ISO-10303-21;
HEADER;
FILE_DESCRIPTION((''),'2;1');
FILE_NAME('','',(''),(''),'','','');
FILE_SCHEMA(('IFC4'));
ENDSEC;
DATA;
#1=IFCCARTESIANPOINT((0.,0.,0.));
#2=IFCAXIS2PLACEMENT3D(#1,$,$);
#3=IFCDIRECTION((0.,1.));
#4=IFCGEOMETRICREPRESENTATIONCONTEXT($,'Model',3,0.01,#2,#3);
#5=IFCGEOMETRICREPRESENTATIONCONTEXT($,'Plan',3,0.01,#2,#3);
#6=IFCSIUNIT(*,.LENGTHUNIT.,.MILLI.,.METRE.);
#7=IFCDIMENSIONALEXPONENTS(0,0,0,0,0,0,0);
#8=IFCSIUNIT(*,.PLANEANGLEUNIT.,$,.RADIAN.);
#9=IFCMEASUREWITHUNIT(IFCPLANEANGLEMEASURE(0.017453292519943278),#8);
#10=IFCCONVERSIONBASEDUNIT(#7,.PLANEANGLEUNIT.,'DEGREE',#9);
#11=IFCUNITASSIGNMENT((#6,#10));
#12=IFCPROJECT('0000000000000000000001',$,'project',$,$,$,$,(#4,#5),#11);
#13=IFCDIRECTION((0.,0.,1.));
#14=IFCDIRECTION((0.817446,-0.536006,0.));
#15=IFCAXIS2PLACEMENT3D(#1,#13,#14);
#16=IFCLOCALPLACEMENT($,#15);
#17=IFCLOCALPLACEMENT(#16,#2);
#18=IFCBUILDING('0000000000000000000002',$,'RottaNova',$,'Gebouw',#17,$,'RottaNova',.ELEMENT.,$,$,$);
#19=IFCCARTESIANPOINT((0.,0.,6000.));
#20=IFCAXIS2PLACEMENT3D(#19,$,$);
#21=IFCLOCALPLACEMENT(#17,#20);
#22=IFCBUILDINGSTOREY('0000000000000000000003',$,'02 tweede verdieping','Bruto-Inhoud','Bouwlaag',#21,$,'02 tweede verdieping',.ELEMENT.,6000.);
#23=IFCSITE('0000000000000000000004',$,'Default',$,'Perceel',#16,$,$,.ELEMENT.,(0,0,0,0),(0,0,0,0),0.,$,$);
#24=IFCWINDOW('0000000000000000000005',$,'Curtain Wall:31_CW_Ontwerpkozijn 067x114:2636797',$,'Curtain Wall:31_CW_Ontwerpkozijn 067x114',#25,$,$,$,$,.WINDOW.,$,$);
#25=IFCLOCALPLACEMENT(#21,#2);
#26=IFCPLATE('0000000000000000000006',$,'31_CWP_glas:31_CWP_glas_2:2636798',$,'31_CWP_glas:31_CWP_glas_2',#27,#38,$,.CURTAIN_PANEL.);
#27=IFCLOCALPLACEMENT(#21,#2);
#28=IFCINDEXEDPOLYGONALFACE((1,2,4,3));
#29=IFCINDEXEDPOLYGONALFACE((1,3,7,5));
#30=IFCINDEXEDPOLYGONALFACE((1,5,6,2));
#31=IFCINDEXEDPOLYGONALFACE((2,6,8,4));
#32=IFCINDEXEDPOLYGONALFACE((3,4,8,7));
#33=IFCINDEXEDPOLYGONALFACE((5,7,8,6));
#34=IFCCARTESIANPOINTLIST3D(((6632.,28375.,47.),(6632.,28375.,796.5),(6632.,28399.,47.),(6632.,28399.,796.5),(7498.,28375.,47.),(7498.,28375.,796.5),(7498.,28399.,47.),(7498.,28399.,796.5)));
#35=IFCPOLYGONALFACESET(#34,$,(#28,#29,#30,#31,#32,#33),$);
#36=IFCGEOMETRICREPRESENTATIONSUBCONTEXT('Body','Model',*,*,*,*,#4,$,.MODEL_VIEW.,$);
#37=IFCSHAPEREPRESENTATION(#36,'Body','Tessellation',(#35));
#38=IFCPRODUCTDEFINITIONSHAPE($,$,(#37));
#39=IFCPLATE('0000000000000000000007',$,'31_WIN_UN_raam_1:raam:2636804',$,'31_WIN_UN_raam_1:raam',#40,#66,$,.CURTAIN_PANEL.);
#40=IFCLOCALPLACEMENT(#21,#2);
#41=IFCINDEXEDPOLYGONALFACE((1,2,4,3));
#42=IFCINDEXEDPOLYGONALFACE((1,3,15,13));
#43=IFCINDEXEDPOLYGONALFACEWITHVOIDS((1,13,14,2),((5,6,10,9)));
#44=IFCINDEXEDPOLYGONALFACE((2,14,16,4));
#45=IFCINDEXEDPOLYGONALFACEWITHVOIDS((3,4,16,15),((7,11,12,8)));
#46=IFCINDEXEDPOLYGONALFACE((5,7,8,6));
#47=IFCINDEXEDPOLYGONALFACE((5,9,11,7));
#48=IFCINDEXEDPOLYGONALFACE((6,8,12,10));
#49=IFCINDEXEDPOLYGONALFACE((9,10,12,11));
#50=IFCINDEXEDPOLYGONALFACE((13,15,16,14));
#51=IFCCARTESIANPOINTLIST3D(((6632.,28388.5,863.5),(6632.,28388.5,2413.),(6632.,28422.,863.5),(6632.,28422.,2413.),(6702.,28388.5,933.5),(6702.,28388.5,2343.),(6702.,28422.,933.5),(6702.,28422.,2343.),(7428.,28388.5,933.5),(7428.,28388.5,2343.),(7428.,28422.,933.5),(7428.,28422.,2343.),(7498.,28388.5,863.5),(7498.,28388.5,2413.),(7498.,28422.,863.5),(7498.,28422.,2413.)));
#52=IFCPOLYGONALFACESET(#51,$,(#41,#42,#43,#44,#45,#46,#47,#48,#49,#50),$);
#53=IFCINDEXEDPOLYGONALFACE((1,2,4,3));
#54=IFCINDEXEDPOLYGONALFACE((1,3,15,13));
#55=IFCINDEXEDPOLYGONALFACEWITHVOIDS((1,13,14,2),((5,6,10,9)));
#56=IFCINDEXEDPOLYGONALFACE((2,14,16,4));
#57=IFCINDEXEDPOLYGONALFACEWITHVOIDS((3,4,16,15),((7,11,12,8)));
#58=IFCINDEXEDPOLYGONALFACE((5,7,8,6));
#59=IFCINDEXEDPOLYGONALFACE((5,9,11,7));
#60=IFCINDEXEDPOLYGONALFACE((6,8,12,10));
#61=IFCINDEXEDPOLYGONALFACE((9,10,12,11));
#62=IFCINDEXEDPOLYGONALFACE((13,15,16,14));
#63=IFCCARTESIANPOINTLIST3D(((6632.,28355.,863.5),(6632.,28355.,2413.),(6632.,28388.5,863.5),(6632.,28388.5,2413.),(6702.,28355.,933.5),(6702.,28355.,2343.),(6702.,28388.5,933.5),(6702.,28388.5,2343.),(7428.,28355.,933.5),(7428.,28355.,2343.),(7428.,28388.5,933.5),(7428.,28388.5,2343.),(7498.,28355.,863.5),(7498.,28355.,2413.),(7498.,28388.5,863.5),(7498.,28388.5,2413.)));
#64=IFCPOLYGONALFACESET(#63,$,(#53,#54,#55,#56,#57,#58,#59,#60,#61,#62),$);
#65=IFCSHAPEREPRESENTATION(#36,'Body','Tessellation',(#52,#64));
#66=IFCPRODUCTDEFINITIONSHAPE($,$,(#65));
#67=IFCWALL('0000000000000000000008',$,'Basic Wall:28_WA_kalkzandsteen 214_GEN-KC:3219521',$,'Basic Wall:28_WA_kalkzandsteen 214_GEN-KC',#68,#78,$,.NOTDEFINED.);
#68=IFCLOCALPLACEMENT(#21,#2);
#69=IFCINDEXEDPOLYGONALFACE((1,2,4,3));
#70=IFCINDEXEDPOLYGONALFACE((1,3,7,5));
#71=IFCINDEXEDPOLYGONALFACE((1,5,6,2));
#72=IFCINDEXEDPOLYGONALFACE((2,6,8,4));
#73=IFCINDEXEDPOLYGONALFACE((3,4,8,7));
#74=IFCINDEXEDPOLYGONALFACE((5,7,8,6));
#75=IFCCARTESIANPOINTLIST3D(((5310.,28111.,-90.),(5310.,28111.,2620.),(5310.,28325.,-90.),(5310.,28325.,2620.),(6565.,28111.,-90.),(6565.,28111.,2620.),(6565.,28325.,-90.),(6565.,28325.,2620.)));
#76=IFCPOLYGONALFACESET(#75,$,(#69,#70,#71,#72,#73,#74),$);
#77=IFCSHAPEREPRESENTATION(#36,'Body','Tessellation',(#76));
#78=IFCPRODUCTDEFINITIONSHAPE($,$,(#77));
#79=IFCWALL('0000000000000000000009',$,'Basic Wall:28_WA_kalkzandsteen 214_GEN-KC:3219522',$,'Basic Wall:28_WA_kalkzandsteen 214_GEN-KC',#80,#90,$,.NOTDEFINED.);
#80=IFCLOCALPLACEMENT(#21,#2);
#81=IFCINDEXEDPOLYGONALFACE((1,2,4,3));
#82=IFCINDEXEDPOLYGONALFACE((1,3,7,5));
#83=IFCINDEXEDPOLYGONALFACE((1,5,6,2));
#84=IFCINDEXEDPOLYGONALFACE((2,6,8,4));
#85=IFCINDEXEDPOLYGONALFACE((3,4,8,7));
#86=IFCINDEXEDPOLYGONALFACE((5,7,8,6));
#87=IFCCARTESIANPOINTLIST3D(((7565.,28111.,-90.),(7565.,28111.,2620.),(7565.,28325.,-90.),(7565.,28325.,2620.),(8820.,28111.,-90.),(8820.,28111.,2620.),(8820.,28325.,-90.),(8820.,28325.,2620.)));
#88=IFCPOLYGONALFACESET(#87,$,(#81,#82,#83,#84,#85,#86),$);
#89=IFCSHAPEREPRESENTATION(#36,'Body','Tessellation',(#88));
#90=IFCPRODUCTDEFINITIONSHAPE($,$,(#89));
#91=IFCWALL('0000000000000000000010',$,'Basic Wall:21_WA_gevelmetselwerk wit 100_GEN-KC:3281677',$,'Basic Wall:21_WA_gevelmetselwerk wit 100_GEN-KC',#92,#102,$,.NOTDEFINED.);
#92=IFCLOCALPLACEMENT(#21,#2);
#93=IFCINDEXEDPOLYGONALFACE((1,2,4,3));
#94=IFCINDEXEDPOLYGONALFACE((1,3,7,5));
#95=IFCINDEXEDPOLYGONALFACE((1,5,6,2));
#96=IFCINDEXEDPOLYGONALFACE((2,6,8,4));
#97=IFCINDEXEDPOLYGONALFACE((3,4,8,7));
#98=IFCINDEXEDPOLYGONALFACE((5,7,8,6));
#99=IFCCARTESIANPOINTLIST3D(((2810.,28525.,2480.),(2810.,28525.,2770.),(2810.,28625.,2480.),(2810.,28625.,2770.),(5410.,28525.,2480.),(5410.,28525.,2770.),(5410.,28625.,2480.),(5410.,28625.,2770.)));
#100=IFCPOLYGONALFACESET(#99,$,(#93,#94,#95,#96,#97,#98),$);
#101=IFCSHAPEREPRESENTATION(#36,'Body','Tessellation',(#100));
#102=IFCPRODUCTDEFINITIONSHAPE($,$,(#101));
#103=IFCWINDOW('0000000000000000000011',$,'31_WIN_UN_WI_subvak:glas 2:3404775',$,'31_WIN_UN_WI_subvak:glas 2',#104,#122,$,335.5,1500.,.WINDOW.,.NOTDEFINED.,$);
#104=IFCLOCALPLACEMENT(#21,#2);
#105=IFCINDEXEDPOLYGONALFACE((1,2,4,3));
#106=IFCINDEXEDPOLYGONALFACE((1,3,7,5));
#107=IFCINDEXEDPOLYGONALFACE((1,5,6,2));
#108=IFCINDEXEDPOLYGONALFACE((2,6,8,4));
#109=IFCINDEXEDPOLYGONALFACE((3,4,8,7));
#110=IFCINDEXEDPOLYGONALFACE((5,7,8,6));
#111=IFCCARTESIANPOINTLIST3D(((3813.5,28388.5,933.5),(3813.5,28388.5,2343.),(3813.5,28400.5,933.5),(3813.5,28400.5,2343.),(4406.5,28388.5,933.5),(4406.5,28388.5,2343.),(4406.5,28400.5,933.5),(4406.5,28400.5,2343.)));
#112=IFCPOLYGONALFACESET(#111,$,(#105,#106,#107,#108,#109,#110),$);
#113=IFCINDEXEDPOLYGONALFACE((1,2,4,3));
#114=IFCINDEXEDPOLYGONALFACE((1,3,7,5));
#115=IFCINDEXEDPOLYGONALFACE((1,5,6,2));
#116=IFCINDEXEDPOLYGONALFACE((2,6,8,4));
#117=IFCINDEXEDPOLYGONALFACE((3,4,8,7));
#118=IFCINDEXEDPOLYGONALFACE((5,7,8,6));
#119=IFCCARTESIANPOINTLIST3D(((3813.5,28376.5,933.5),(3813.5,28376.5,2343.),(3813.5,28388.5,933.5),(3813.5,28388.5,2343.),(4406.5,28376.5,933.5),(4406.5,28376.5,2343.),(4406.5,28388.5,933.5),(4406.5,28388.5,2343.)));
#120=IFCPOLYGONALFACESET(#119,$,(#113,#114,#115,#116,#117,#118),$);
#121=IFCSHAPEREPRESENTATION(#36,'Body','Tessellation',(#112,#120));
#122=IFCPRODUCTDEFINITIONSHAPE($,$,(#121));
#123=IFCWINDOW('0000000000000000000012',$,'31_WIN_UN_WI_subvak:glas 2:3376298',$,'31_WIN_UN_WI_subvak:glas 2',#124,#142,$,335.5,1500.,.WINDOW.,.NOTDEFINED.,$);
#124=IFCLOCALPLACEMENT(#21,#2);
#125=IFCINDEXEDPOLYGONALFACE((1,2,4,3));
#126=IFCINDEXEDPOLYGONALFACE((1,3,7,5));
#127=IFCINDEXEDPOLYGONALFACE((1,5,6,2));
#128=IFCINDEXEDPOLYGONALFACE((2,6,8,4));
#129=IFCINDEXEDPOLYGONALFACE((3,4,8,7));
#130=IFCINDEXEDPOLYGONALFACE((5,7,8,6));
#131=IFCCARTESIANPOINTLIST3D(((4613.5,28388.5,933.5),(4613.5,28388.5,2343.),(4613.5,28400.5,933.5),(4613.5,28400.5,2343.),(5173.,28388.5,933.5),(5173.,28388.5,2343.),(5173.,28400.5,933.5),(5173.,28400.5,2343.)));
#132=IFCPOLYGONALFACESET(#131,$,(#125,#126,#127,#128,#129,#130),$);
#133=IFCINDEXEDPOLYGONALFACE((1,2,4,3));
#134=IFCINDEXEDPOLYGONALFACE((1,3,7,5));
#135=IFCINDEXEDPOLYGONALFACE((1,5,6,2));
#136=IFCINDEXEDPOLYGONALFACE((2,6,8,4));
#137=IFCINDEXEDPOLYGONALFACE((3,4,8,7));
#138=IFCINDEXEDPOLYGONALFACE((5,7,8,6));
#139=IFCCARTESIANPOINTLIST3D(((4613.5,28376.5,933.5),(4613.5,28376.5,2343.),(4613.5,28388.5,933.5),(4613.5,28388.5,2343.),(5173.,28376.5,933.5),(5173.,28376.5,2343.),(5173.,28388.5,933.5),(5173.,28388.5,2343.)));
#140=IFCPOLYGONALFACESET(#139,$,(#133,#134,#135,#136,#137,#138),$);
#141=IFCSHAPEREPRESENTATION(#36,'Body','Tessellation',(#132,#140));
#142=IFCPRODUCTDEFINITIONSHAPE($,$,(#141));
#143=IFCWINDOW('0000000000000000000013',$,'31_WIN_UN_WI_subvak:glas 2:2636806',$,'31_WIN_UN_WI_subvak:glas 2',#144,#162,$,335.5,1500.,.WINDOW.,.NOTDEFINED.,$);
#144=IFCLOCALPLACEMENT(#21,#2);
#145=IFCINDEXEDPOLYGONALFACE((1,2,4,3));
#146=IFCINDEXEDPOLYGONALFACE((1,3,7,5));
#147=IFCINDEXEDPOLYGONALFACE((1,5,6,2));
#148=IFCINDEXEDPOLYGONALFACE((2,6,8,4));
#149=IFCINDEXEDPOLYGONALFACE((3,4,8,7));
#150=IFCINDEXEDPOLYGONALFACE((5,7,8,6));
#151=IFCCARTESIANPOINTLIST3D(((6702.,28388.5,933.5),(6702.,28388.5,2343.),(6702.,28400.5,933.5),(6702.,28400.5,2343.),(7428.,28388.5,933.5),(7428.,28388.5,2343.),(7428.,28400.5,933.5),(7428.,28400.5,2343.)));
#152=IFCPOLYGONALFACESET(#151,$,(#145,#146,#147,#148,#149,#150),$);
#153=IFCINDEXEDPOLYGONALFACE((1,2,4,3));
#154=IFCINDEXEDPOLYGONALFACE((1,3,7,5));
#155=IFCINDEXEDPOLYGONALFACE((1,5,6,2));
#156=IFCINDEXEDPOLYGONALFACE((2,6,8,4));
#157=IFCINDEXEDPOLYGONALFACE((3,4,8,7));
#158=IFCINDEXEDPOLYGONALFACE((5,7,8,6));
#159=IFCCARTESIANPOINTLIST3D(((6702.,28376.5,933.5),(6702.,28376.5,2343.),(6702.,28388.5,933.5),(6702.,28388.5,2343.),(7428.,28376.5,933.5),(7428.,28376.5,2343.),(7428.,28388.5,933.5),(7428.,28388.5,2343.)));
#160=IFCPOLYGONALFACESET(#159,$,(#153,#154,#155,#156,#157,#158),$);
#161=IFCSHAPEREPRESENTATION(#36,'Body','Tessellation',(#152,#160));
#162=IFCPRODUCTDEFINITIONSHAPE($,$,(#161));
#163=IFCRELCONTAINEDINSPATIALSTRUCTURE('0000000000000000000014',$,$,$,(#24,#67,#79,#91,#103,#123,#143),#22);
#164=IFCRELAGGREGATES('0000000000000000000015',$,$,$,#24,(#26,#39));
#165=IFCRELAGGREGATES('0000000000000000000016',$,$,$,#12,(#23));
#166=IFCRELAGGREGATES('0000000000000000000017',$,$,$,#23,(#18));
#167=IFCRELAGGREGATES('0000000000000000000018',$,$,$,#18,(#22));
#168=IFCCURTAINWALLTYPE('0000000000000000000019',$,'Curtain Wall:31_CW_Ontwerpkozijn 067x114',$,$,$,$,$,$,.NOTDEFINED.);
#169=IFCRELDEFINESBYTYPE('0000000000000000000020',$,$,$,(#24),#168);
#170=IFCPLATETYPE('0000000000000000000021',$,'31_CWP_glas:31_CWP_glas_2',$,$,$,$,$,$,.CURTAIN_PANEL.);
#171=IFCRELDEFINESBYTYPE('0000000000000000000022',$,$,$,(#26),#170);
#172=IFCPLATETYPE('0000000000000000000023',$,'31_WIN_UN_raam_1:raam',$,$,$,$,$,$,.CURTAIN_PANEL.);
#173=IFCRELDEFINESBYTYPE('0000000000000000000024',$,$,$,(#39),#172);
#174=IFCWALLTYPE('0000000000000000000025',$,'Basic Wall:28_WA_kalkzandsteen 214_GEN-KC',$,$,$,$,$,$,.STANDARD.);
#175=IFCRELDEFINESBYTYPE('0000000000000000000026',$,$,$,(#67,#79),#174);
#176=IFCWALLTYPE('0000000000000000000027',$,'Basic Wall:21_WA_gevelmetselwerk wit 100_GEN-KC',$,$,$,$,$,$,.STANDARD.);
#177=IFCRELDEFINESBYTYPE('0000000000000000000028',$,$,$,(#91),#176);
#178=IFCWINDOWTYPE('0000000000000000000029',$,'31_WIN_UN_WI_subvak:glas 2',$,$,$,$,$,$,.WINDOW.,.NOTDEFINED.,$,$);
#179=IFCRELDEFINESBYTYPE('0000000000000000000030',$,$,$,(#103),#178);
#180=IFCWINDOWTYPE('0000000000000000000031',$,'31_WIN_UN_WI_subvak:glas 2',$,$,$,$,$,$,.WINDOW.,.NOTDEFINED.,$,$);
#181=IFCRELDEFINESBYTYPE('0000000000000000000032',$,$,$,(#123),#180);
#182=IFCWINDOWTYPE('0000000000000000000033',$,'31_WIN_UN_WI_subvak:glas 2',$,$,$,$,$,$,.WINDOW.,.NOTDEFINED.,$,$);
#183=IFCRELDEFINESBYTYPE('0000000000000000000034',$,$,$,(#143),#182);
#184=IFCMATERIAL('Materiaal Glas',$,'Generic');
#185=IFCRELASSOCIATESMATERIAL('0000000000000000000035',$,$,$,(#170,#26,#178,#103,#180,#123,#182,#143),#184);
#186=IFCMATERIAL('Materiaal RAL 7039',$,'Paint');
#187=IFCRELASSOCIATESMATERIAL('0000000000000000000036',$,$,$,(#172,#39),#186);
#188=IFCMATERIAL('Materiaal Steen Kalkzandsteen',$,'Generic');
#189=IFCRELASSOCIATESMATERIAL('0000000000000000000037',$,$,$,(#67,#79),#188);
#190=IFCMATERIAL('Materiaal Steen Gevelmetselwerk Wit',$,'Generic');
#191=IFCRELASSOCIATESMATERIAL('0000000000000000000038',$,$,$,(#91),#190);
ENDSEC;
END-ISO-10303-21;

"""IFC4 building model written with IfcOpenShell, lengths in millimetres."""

from ifc_helpers import new_model, entity, si_unit, converted_unit, direction, frame, origin, place, context, subcontext, project, spatial, indexed_curve, outline, extrude, source, transform, mapped, material, type_object, type_shapes, element, aggregate, save


model = new_model("IFC4")

# Units and contexts
model_context = context("Model", 3, precision=0.01, world=origin(), true_north=direction((0.0, 1.0)))
plan_context = context("Plan", 3, precision=0.01, world=origin(), true_north=direction((0.0, 1.0)))
body_context = subcontext(model_context, "Body", "Model", "MODEL_VIEW")
ifc_project = project(units=[si_unit("LENGTHUNIT", "METRE", prefix="MILLI"), converted_unit("PLANEANGLEUNIT", "DEGREE", entity("IfcPlaneAngleMeasure", 0.017453292519943278), si_unit("PLANEANGLEUNIT", "RADIAN"), dimensions=[0, 0, 0, 0, 0, 0, 0])], contexts=[model_context, plan_context])

# Site, building, storey
site_placement = place(None, frame((0.0, 0.0, 0.0), z_axis=(0.0, 0.0, 1.0), x_axis=(0.817446, -0.536006, 0.0)))
site = spatial("IfcSite", under=ifc_project, at=site_placement, Name="Default", ObjectType="Perceel", CompositionType="ELEMENT", RefLatitude=(0, 0, 0, 0), RefLongitude=(0, 0, 0, 0), RefElevation=0.0)
building_placement = place(site_placement, origin())
building = spatial("IfcBuilding", under=site, at=building_placement, Name="RottaNova", ObjectType="Gebouw", LongName="RottaNova", CompositionType="ELEMENT")
storey_placement = place(building_placement, frame((0.0, 0.0, 6000.0)))
storey = spatial("IfcBuildingStorey", under=building, at=storey_placement, Name="02 tweede verdieping", Description="Bruto-Inhoud", ObjectType="Bouwlaag", LongName="02 tweede verdieping", CompositionType="ELEMENT", Elevation=6000.0)

# Window
curtain_wall_type = type_object("IfcCurtainWallType", Name="Curtain Wall:31_CW_Ontwerpkozijn 067x114", PredefinedType="NOTDEFINED")
window_1_placement = place(storey_placement, frame((0.0, 0.0, -6000.0)))
window_1 = element("IfcWindow", 1, at=window_1_placement, inside=storey, type_object=curtain_wall_type, Name="Curtain Wall:31_CW_Ontwerpkozijn 067x114:2636797", ObjectType="Curtain Wall:31_CW_Ontwerpkozijn 067x114", PredefinedType="WINDOW")

# Plates
ifc_material_1 = material(Name="Materiaal Glas", Category="Generic")
ifc_material_2 = material(Name="Materiaal RAL 7039", Category="Paint")
plate_type_1 = type_object("IfcPlateType", Name="31_CWP_glas:31_CWP_glas_2", PredefinedType="CURTAIN_PANEL", material=ifc_material_1)
shared_shape_1 = source(origin(), body_context, "Body", "SweptSolid", [
    extrude(outline(indexed_curve([(-12.0, -433.0), (12.0, -433.0), (12.0, 433.0), (-12.0, 433.0), (-12.0, -433.0)], self_intersect=False)), frame((0.0, 57.0, 0.0), z_axis=(0.0, 0.0, 1.0), x_axis=(0.0, 1.0, 0.0)), (0.0, 0.0, 1.0), 749.5),
])
type_shapes(plate_type_1, [shared_shape_1])
plate_1_placement = place(window_1_placement, frame((7065.0, 28330.0, 6047.0)))
plate_1 = element("IfcPlate", 2, at=plate_1_placement, type_object=plate_type_1, material=ifc_material_1, Name="31_CWP_glas:31_CWP_glas_2:2636798", ObjectType="31_CWP_glas:31_CWP_glas_2", PredefinedType="CURTAIN_PANEL", context=body_context, shape_type="MappedRepresentation", body=[
    mapped(shared_shape_1, transform((0.0, 0.0, 0.0), scale=1.0)),
])
plate_type_2 = type_object("IfcPlateType", Name="31_WIN_UN_raam_1:raam", PredefinedType="CURTAIN_PANEL", material=ifc_material_2)
shared_shape_2 = source(origin(), body_context, "Body", "SweptSolid", [
    extrude(outline(indexed_curve([(-433.0, -774.7), (433.0, -774.7), (433.0, 774.7), (-433.0, 774.7), (-433.0, -774.7)], self_intersect=False), holes=[indexed_curve([(-363.0, 704.7), (363.0, 704.7), (363.0, -704.8), (-363.0, -704.8), (-363.0, 704.7)], self_intersect=False)]), frame((0.0, 58.5, 774.8), z_axis=(0.0, 1.0, 0.0), x_axis=(1.0, 0.0, 0.0)), (0.0, 0.0, 1.0), 33.5),
    extrude(outline(indexed_curve([(-433.0, -774.7), (433.0, -774.7), (433.0, 774.7), (-433.0, 774.7), (-433.0, -774.7)], self_intersect=False), holes=[indexed_curve([(-363.0, 704.7), (363.0, 704.7), (363.0, -704.8), (-363.0, -704.8), (-363.0, 704.7)], self_intersect=False)]), frame((0.0, 25.0, 774.8), z_axis=(0.0, 1.0, 0.0), x_axis=(1.0, 0.0, 0.0)), (0.0, 0.0, 1.0), 33.5),
])
type_shapes(plate_type_2, [shared_shape_2])
plate_2_placement = place(window_1_placement, frame((7065.0, 28330.0, 6863.5)))
plate_2 = element("IfcPlate", 3, at=plate_2_placement, type_object=plate_type_2, material=ifc_material_2, Name="31_WIN_UN_raam_1:raam:2636804", ObjectType="31_WIN_UN_raam_1:raam", PredefinedType="CURTAIN_PANEL", context=body_context, shape_type="MappedRepresentation", body=[
    mapped(shared_shape_2, transform((0.0, 0.0, 0.0), scale=1.0)),
])
aggregate(window_1, [plate_1, plate_2])

# Walls
ifc_material_3 = material(Name="Materiaal Steen Kalkzandsteen", Category="Generic")
wall_type_1 = type_object("IfcWallType", Name="Basic Wall:28_WA_kalkzandsteen 214_GEN-KC", PredefinedType="STANDARD")
wall_1_placement = place(storey_placement, frame((5310.0, 28218.0, -90.0)))
element("IfcWall", 4, at=wall_1_placement, inside=storey, type_object=wall_type_1, material=ifc_material_3, Name="Basic Wall:28_WA_kalkzandsteen 214_GEN-KC:3219521", ObjectType="Basic Wall:28_WA_kalkzandsteen 214_GEN-KC", PredefinedType="NOTDEFINED", context=body_context, shape_type="SweptSolid", body=[
    extrude(outline(indexed_curve([(1255.0, 107.0), (0.0, 107.0), (0.0, -107.0), (1255.0, -107.0), (1255.0, 107.0)], self_intersect=False)), origin(), (0.0, 0.0, 1.0), 2710.0),
])
wall_2_placement = place(storey_placement, frame((7565.0, 28218.0, -90.0)))
element("IfcWall", 5, at=wall_2_placement, inside=storey, type_object=wall_type_1, material=ifc_material_3, Name="Basic Wall:28_WA_kalkzandsteen 214_GEN-KC:3219522", ObjectType="Basic Wall:28_WA_kalkzandsteen 214_GEN-KC", PredefinedType="NOTDEFINED", context=body_context, shape_type="SweptSolid", body=[
    extrude(outline(indexed_curve([(1255.0, 107.0), (0.0, 107.0), (0.0, -107.0), (1255.0, -107.0), (1255.0, 107.0)], self_intersect=False)), origin(), (0.0, 0.0, 1.0), 2710.0),
])
ifc_material_4 = material(Name="Materiaal Steen Gevelmetselwerk Wit", Category="Generic")
wall_type_2 = type_object("IfcWallType", Name="Basic Wall:21_WA_gevelmetselwerk wit 100_GEN-KC", PredefinedType="STANDARD")
wall_3_placement = place(storey_placement, frame((5410.0, 28575.0, 2480.0), z_axis=(0.0, 0.0, 1.0), x_axis=(-1.0, 0.0, 0.0)))
element("IfcWall", 6, at=wall_3_placement, inside=storey, type_object=wall_type_2, material=ifc_material_4, Name="Basic Wall:21_WA_gevelmetselwerk wit 100_GEN-KC:3281677", ObjectType="Basic Wall:21_WA_gevelmetselwerk wit 100_GEN-KC", PredefinedType="NOTDEFINED", context=body_context, shape_type="SweptSolid", body=[
    extrude(outline(indexed_curve([(2600.0, 50.0), (0.0, 50.0), (0.0, -50.0), (2600.0, -50.0), (2600.0, 50.0)], self_intersect=False)), origin(), (0.0, 0.0, 1.0), 290.0),
])

# Windows
window_type_1 = type_object("IfcWindowType", Name="31_WIN_UN_WI_subvak:glas 2", PartitioningType="NOTDEFINED", PredefinedType="WINDOW", material=ifc_material_1)
shared_shape_3 = source(origin(), body_context, "Body", "SweptSolid", [
    extrude(outline(indexed_curve([(-296.5, -6.0), (296.5, -6.0), (296.5, 6.0), (-296.5, 6.0), (-296.5, -6.0)], self_intersect=False)), frame((0.0, -6.0, 0.0)), (0.0, 0.0, 1.0), 1409.5),
    extrude(outline(indexed_curve([(-296.5, -6.0), (296.5, -6.0), (296.5, 6.0), (-296.5, 6.0), (-296.5, -6.0)], self_intersect=False)), frame((0.0, 6.0, 0.0)), (0.0, 0.0, 1.0), 1409.5),
])
type_shapes(window_type_1, [shared_shape_3])
window_2_placement = place(storey_placement, frame((4110.0, 28388.5, 933.5), z_axis=(0.0, 0.0, 1.0), x_axis=(-1.0, 0.0, 0.0)))
element("IfcWindow", 7, at=window_2_placement, inside=storey, type_object=window_type_1, material=ifc_material_1, Name="31_WIN_UN_WI_subvak:glas 2:3404775", ObjectType="31_WIN_UN_WI_subvak:glas 2", OverallHeight=335.5, OverallWidth=1500.0, PartitioningType="NOTDEFINED", PredefinedType="WINDOW", context=body_context, shape_type="MappedRepresentation", body=[
    mapped(shared_shape_3, transform((0.0, 0.0, 0.0), scale=1.0)),
])
window_type_2 = type_object("IfcWindowType", Name="31_WIN_UN_WI_subvak:glas 2", PartitioningType="NOTDEFINED", PredefinedType="WINDOW", material=ifc_material_1)
shared_shape_4 = source(origin(), body_context, "Body", "SweptSolid", [
    extrude(outline(indexed_curve([(-279.8, -6.0), (279.8, -6.0), (279.8, 6.0), (-279.8, 6.0), (-279.8, -6.0)], self_intersect=False)), frame((0.0, -6.0, 0.0)), (0.0, 0.0, 1.0), 1409.5),
    extrude(outline(indexed_curve([(-279.8, -6.0), (279.8, -6.0), (279.8, 6.0), (-279.8, 6.0), (-279.8, -6.0)], self_intersect=False)), frame((0.0, 6.0, 0.0)), (0.0, 0.0, 1.0), 1409.5),
])
type_shapes(window_type_2, [shared_shape_4])
window_3_placement = place(storey_placement, frame((4893.2, 28388.5, 933.5), z_axis=(0.0, 0.0, 1.0), x_axis=(-1.0, 0.0, 0.0)))
element("IfcWindow", 8, at=window_3_placement, inside=storey, type_object=window_type_2, material=ifc_material_1, Name="31_WIN_UN_WI_subvak:glas 2:3376298", ObjectType="31_WIN_UN_WI_subvak:glas 2", OverallHeight=335.5, OverallWidth=1500.0, PartitioningType="NOTDEFINED", PredefinedType="WINDOW", context=body_context, shape_type="MappedRepresentation", body=[
    mapped(shared_shape_4, transform((0.0, 0.0, 0.0), scale=1.0)),
])
window_type_3 = type_object("IfcWindowType", Name="31_WIN_UN_WI_subvak:glas 2", PartitioningType="NOTDEFINED", PredefinedType="WINDOW", material=ifc_material_1)
shared_shape_5 = source(origin(), body_context, "Body", "SweptSolid", [
    extrude(outline(indexed_curve([(-6.0, -363.0), (6.0, -363.0), (6.0, 363.0), (-6.0, 363.0), (-6.0, -363.0)], self_intersect=False)), frame((0.0, 6.0, 0.0), z_axis=(0.0, 0.0, 1.0), x_axis=(0.0, -1.0, 0.0)), (0.0, 0.0, 1.0), 1409.5),
    extrude(outline(indexed_curve([(-6.0, -363.0), (6.0, -363.0), (6.0, 363.0), (-6.0, 363.0), (-6.0, -363.0)], self_intersect=False)), frame((0.0, -6.0, 0.0), z_axis=(0.0, 0.0, 1.0), x_axis=(0.0, -1.0, 0.0)), (0.0, 0.0, 1.0), 1409.5),
])
type_shapes(window_type_3, [shared_shape_5])
window_4_placement = place(storey_placement, frame((7065.0, 28388.5, 933.5)))
element("IfcWindow", 9, at=window_4_placement, inside=storey, type_object=window_type_3, material=ifc_material_1, Name="31_WIN_UN_WI_subvak:glas 2:2636806", ObjectType="31_WIN_UN_WI_subvak:glas 2", OverallHeight=335.5, OverallWidth=1500.0, PartitioningType="NOTDEFINED", PredefinedType="WINDOW", context=body_context, shape_type="MappedRepresentation", body=[
    mapped(shared_shape_5, transform((0.0, 0.0, 0.0), scale=1.0)),
])

save(model, "model.ifc")
